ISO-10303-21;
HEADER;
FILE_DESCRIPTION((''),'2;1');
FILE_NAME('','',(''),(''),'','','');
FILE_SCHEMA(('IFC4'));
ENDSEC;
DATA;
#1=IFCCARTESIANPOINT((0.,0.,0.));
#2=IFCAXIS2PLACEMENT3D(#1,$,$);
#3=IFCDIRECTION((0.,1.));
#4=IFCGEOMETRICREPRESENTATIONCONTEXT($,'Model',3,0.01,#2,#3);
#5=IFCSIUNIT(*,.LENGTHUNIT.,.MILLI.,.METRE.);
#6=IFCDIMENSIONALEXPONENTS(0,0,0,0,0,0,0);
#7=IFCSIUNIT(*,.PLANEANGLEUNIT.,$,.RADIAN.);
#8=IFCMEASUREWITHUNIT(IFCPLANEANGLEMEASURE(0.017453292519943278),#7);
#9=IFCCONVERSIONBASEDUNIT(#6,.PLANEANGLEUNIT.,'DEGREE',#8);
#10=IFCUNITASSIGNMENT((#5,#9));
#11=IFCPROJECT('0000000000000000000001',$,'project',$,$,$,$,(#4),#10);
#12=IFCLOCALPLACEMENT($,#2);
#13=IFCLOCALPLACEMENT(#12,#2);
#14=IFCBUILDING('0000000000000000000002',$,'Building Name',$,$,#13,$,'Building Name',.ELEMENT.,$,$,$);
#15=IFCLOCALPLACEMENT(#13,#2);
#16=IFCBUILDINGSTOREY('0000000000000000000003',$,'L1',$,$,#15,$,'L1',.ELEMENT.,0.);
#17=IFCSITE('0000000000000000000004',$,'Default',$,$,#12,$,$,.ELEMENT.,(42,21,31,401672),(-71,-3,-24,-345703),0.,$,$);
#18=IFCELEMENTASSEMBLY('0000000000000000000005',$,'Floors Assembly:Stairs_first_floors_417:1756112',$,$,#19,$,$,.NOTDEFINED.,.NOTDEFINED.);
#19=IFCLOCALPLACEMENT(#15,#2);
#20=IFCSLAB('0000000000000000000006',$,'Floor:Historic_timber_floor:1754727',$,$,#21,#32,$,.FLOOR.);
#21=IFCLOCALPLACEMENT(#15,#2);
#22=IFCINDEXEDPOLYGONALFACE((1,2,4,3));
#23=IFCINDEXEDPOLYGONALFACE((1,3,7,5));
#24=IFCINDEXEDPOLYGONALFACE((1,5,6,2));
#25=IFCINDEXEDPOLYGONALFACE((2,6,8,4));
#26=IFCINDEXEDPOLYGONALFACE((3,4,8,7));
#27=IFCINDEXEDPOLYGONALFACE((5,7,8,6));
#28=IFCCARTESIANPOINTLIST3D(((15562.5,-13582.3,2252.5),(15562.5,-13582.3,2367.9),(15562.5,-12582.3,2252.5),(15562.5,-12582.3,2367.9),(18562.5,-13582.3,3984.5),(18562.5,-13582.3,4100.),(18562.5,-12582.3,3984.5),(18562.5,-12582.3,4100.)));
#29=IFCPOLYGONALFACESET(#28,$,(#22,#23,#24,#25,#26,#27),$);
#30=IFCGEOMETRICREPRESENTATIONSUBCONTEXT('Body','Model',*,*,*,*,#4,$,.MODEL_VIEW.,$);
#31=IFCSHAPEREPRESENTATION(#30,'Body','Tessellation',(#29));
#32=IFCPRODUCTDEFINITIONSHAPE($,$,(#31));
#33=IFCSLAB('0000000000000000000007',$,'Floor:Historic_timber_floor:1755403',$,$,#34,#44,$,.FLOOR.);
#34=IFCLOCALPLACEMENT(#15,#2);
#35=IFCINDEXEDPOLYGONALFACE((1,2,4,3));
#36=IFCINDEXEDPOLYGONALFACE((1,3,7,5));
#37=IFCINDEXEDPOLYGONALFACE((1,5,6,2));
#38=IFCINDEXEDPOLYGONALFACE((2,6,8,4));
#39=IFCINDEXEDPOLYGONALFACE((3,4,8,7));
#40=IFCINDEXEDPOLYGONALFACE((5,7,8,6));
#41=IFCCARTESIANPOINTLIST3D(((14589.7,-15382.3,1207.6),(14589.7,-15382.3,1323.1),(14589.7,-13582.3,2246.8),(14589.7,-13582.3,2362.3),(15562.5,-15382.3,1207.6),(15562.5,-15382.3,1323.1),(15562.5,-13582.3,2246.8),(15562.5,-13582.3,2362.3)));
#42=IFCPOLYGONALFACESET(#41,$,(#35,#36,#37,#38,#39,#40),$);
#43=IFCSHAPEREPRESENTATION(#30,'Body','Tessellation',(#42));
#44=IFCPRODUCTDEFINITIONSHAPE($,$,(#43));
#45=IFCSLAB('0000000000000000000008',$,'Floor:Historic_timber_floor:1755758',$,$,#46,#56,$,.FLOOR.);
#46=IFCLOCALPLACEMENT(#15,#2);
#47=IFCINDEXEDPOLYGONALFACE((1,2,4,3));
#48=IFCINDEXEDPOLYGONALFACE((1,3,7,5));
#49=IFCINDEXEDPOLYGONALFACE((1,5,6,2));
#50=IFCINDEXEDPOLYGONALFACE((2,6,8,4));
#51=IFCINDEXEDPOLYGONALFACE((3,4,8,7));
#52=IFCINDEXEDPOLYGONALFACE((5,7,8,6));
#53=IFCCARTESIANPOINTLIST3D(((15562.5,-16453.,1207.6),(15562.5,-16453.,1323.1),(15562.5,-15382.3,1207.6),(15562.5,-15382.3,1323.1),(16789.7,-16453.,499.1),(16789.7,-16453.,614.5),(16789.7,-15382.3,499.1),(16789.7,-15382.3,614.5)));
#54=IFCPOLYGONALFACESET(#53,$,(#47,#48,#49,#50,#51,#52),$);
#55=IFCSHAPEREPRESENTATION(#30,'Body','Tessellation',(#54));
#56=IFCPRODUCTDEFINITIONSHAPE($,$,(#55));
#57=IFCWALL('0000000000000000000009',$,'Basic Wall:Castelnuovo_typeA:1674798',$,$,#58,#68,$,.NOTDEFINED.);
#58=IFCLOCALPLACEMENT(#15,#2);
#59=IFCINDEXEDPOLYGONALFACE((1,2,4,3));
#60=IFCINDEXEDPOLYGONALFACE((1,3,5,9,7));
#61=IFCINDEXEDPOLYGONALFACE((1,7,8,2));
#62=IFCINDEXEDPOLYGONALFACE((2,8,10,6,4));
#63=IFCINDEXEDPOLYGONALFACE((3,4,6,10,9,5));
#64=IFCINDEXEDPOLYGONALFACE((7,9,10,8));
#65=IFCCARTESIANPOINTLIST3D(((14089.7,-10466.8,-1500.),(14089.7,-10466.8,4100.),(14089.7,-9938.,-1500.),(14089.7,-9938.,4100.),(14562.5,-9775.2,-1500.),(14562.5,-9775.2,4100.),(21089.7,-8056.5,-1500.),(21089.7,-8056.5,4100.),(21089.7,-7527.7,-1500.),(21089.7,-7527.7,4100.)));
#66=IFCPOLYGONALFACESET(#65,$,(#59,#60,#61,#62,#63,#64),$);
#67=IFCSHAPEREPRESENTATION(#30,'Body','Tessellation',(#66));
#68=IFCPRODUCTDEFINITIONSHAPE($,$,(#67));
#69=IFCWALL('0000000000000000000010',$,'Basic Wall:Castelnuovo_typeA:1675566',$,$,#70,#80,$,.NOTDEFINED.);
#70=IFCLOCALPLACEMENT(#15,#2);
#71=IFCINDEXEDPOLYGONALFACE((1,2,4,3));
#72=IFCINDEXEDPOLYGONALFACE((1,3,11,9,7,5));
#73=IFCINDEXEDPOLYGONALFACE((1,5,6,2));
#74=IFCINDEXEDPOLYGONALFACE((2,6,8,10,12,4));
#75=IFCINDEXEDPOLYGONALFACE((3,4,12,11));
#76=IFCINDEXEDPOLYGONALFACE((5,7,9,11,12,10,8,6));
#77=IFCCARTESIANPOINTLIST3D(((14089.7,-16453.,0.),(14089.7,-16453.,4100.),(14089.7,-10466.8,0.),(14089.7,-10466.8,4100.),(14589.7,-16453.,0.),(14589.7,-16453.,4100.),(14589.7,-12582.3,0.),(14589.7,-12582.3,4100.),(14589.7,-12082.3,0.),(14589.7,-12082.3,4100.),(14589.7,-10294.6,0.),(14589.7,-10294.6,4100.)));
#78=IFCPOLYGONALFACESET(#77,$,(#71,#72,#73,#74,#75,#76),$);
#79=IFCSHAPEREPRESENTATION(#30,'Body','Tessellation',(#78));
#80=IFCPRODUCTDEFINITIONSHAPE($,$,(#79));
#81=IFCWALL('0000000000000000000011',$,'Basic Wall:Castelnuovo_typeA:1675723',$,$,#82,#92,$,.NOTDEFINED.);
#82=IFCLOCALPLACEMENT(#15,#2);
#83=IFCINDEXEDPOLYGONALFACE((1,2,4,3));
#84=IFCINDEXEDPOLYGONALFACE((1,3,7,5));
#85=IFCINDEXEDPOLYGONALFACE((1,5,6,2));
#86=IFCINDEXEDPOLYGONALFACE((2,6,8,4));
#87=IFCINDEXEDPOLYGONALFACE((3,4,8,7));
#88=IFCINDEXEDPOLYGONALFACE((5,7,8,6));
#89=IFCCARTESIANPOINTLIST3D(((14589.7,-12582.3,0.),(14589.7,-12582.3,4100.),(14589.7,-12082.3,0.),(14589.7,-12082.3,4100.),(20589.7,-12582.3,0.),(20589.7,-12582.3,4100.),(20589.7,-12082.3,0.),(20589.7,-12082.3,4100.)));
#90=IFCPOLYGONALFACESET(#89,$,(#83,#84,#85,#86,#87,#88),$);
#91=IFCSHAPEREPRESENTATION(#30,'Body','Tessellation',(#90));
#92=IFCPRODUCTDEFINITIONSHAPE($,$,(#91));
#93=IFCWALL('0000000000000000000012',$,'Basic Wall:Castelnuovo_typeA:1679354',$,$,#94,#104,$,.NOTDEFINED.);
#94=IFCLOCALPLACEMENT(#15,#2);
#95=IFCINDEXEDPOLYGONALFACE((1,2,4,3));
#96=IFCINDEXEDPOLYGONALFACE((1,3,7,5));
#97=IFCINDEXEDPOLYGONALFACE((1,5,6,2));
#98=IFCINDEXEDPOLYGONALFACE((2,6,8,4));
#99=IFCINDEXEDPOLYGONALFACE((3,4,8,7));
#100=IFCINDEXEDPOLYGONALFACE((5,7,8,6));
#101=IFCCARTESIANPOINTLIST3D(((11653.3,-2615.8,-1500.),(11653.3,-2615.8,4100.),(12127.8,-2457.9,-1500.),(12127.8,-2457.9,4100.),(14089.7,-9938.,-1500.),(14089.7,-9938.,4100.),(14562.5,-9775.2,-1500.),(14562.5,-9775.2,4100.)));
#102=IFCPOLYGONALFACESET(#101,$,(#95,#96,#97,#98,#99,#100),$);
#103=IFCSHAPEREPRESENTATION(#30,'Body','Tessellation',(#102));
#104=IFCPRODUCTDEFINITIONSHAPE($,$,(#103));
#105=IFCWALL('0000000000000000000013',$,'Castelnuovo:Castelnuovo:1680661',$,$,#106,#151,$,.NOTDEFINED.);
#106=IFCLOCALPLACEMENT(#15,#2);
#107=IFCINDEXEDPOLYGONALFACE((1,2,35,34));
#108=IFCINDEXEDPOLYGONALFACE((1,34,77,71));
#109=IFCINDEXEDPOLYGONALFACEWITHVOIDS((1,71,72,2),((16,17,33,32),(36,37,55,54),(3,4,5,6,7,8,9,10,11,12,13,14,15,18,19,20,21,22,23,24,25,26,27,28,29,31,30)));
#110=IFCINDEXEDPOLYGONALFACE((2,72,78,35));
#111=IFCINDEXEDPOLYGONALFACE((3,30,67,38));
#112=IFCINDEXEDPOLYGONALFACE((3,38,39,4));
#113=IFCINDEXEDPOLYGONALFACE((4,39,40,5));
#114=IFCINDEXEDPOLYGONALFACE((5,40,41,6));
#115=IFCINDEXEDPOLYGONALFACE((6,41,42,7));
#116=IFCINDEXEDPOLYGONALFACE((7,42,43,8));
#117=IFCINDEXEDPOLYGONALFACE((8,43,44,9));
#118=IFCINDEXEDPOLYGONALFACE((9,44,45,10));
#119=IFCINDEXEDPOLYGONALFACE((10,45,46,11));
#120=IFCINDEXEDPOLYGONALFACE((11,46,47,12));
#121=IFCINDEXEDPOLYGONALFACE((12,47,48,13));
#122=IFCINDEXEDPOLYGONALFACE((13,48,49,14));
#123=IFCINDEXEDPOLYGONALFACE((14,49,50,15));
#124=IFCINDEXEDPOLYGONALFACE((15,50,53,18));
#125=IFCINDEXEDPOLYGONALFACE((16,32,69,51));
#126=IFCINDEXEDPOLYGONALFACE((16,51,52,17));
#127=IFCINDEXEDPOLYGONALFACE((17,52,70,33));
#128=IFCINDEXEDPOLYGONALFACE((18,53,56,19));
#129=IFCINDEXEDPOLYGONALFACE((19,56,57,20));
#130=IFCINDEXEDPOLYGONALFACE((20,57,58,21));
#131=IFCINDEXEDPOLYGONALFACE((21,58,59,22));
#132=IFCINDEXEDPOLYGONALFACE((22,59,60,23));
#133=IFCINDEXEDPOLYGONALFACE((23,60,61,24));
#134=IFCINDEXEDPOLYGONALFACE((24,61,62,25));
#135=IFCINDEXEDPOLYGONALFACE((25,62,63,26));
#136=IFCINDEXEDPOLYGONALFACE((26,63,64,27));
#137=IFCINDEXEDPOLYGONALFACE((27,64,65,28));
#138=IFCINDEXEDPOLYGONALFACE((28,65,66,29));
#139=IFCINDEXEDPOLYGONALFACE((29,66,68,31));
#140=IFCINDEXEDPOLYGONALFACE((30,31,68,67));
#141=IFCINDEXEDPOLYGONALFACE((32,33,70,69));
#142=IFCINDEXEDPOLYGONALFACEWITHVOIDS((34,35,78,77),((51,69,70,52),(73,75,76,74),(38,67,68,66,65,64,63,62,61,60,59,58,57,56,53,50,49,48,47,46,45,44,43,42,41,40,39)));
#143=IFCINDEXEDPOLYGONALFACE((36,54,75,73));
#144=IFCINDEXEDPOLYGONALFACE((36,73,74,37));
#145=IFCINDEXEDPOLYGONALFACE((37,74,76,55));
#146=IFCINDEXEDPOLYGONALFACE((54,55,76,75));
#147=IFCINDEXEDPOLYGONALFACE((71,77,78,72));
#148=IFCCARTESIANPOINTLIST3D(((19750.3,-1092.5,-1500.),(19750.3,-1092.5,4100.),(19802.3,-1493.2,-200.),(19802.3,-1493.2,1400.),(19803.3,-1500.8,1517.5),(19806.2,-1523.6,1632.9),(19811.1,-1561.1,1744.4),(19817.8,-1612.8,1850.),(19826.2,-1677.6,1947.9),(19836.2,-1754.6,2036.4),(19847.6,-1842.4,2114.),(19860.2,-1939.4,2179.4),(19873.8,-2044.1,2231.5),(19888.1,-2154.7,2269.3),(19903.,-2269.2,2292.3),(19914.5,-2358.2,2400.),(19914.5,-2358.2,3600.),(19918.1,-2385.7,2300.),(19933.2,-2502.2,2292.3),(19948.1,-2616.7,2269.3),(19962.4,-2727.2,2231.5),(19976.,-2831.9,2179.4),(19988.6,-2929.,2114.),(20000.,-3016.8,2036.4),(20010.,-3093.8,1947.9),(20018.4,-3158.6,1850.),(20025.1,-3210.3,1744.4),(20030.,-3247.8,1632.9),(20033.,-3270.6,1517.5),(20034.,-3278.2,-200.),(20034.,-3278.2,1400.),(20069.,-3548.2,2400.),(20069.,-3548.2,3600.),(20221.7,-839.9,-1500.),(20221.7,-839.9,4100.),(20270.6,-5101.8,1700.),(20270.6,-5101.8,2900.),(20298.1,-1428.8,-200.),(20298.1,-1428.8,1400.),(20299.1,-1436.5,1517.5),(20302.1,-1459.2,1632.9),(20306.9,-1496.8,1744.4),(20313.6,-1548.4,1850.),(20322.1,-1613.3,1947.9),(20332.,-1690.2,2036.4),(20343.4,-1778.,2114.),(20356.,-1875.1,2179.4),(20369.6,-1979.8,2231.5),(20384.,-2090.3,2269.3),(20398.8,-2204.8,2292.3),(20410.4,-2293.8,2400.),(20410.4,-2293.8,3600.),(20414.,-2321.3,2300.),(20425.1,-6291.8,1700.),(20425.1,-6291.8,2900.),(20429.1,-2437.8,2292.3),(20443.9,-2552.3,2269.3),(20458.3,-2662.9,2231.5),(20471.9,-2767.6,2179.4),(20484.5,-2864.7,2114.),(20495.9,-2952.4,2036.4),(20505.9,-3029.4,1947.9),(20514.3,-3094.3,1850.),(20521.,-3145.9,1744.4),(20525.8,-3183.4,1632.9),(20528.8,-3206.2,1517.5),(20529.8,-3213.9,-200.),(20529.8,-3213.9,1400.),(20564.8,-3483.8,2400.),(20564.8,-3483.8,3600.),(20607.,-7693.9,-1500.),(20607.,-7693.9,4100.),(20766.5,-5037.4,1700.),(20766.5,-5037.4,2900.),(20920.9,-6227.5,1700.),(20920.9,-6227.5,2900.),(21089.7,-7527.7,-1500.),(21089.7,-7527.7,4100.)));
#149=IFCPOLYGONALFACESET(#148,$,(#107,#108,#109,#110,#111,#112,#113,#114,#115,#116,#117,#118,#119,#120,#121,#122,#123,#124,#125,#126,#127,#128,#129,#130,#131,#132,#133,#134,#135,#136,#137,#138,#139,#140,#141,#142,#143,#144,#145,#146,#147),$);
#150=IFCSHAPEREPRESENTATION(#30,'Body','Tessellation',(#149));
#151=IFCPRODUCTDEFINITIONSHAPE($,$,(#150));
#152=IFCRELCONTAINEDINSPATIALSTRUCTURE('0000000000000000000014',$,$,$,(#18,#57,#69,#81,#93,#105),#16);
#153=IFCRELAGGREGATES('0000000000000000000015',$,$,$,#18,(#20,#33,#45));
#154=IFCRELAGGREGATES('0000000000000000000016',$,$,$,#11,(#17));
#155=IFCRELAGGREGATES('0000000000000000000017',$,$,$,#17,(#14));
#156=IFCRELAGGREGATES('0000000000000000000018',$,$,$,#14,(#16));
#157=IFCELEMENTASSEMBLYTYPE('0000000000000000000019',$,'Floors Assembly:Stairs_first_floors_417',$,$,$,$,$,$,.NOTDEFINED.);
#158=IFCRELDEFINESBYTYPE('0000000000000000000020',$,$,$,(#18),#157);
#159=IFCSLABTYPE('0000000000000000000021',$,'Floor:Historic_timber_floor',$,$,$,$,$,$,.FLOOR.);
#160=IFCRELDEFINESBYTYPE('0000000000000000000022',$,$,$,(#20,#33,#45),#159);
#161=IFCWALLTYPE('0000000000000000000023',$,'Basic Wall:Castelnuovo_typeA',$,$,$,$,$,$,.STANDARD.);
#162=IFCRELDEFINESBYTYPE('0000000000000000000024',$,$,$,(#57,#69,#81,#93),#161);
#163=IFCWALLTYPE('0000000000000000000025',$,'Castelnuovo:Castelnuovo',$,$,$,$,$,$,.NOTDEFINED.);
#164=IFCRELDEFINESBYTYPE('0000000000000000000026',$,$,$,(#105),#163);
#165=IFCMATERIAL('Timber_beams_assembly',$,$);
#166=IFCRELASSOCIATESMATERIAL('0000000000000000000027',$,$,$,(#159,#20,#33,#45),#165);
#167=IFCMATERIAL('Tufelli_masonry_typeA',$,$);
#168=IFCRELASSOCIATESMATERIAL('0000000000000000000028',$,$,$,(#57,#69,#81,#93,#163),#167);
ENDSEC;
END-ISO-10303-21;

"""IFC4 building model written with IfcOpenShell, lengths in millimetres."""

from ifc_helpers import new_model, entity, si_unit, converted_unit, direction, frame, frame_2d, origin, place, context, subcontext, project, spatial, line, arc, indexed_curve, rectangle, outline, extrude, material, type_object, element, aggregate, save


model = new_model("IFC4")

# Units and contexts
model_context = context("Model", 3, precision=0.01, world=origin(), true_north=direction((0.0, 1.0)))
body_context = subcontext(model_context, "Body", "Model", "MODEL_VIEW")
ifc_project = project(units=[si_unit("LENGTHUNIT", "METRE", prefix="MILLI"), converted_unit("PLANEANGLEUNIT", "DEGREE", entity("IfcPlaneAngleMeasure", 0.017453292519943278), si_unit("PLANEANGLEUNIT", "RADIAN"), dimensions=[0, 0, 0, 0, 0, 0, 0])], contexts=[model_context])

# Site, building, storey
site_placement = place(None, origin())
site = spatial("IfcSite", under=ifc_project, at=site_placement, Name="Default", CompositionType="ELEMENT", RefLatitude=(42, 21, 31, 401672), RefLongitude=(-71, -3, -24, -345703), RefElevation=0.0)
building_placement = place(site_placement, origin())
building = spatial("IfcBuilding", under=site, at=building_placement, Name="Building Name", LongName="Building Name", CompositionType="ELEMENT")
storey_placement = place(building_placement, origin())
storey = spatial("IfcBuildingStorey", under=building, at=storey_placement, Name="L1", LongName="L1", CompositionType="ELEMENT", Elevation=0.0)

# Element assembly, slabs
element_assembly_type = type_object("IfcElementAssemblyType", Name="Floors Assembly:Stairs_first_floors_417", PredefinedType="NOTDEFINED")
assembly_placement = place(storey_placement, origin())
assembly = element("IfcElementAssembly", 1, at=assembly_placement, inside=storey, type_object=element_assembly_type, Name="Floors Assembly:Stairs_first_floors_417:1756112", AssemblyPlace="NOTDEFINED", PredefinedType="NOTDEFINED")
ifc_material_1 = material(Name="Timber_beams_assembly")
slab_type = type_object("IfcSlabType", Name="Floor:Historic_timber_floor", PredefinedType="FLOOR", material=ifc_material_1)
slab_1_placement = place(assembly_placement, frame((15562.5, -13582.3, 2252.5)))
slab_1 = element("IfcSlab", 2, at=slab_1_placement, type_object=slab_type, material=ifc_material_1, Name="Floor:Historic_timber_floor:1754727", PredefinedType="FLOOR", context=body_context, shape_type="SweptSolid", body=[
    extrude(rectangle(XDim=1000.0, YDim=3464.1, at=frame_2d((-1732.1, -500.0), x_axis=(0.0, -1.0))), frame((3000.0, 1000.0, 1847.5), z_axis=(-0.5, 0.0, 0.866025), x_axis=(0.866025, 0.0, 0.5)), (-0.5, 0.0, -0.866025), 115.5),
])
slab_2_placement = place(assembly_placement, frame((14589.7, -15382.3, 1207.6)))
slab_2 = element("IfcSlab", 3, at=slab_2_placement, type_object=slab_type, material=ifc_material_1, Name="Floor:Historic_timber_floor:1755403", PredefinedType="FLOOR", context=body_context, shape_type="SweptSolid", body=[
    extrude(rectangle(XDim=972.8, YDim=2078.5, at=frame_2d((486.4, -1039.2), x_axis=(1.0, 0.0))), frame((0.0, 1800.0, 1154.7), z_axis=(0.0, -0.5, 0.866025), x_axis=(1.0, 0.0, 0.0)), (0.0, -0.5, -0.866025), 115.5),
])
slab_3_placement = place(assembly_placement, frame((15562.5, -16453.0, 499.1)))
slab_3 = element("IfcSlab", 4, at=slab_3_placement, type_object=slab_type, material=ifc_material_1, Name="Floor:Historic_timber_floor:1755758", PredefinedType="FLOOR", context=body_context, shape_type="SweptSolid", body=[
    extrude(rectangle(XDim=1070.7, YDim=1417.1, at=frame_2d((708.5, 535.3), x_axis=(0.0, -1.0))), frame((0.0, 0.0, 824.0), z_axis=(0.5, 0.0, 0.866025), x_axis=(0.866025, 0.0, -0.5)), (0.5, 0.0, -0.866025), 115.5),
])
aggregate(assembly, [slab_1, slab_2, slab_3])

# Walls
ifc_material_2 = material(Name="Tufelli_masonry_typeA")
wall_type_1 = type_object("IfcWallType", Name="Basic Wall:Castelnuovo_typeA", PredefinedType="STANDARD")
wall_1_placement = place(storey_placement, frame((14008.3, -10230.4, -1500.0), z_axis=(0.0, 0.0, 1.0), x_axis=(0.945519, 0.325568, 0.0)))
element("IfcWall", 5, at=wall_1_placement, inside=storey, type_object=wall_type_1, material=ifc_material_2, Name="Basic Wall:Castelnuovo_typeA:1674798", PredefinedType="NOTDEFINED", context=body_context, shape_type="SweptSolid", body=[
    extrude(outline(indexed_curve([(7403.3, -250.0), (7575.5, 250.0), (672.2, 250.0), (172.2, 250.0), (0.0, -250.0), (7403.3, -250.0)], self_intersect=False)), origin(), (0.0, 0.0, 1.0), 5600.0),
])
wall_2_placement = place(storey_placement, frame((14339.7, -16453.0, 0.0), z_axis=(0.0, 0.0, 1.0), x_axis=(0.0, 1.0, 0.0)))
element("IfcWall", 6, at=wall_2_placement, inside=storey, type_object=wall_type_1, material=ifc_material_2, Name="Basic Wall:Castelnuovo_typeA:1675566", PredefinedType="NOTDEFINED", context=body_context, shape_type="SweptSolid", body=[
    extrude(outline(indexed_curve([(6158.4, -250.0), (5986.3, 250.0), (0.0, 250.0), (0.0, -250.0), (3870.7, -250.0), (4370.7, -250.0), (6158.4, -250.0)], self_intersect=False)), origin(), (0.0, 0.0, 1.0), 4100.0),
])
wall_3_placement = place(storey_placement, frame((14589.7, -12332.3, 0.0)))
element("IfcWall", 7, at=wall_3_placement, inside=storey, type_object=wall_type_1, material=ifc_material_2, Name="Basic Wall:Castelnuovo_typeA:1675723", PredefinedType="NOTDEFINED", context=body_context, shape_type="SweptSolid", body=[
    extrude(outline(indexed_curve([(6000.0, 250.0), (0.0, 250.0), (0.0, -250.0), (6000.0, -250.0), (6000.0, 250.0)], self_intersect=False)), origin(), (0.0, 0.0, 1.0), 4100.0),
])
wall_4_placement = place(storey_placement, frame((11890.5, -2536.8, -1500.0), z_axis=(0.0, 0.0, 1.0), x_axis=(0.315716, -0.948854, 0.0)))
element("IfcWall", 8, at=wall_4_placement, inside=storey, type_object=wall_type_1, material=ifc_material_2, Name="Basic Wall:Castelnuovo_typeA:1679354", PredefinedType="NOTDEFINED", context=body_context, shape_type="SweptSolid", body=[
    extrude(outline(indexed_curve([(7716.9, -250.0), (7711.7, 250.0), (0.0, 250.0), (0.0, -250.0), (7716.9, -250.0)], self_intersect=False)), origin(), (0.0, 0.0, 1.0), 5600.0),
])

# Wall, openings
wall_type_2 = type_object("IfcWallType", Name="Castelnuovo:Castelnuovo", PredefinedType="NOTDEFINED", material=ifc_material_2)
wall_5_placement = place(storey_placement, frame((19750.3, -7693.9, -1500.0), z_axis=(0.0, 0.0, 1.0), x_axis=(0.0, 1.0, 0.0)))
wall_5 = element("IfcWall", 9, at=wall_5_placement, inside=storey, type_object=wall_type_2, Name="Castelnuovo:Castelnuovo:1680661", PredefinedType="NOTDEFINED", context=body_context, shape_type="SweptSolid", body=[
    extrude(outline(indexed_curve([(-929.1, -3281.7), (-418.7, -3281.7), (937.9, 3324.4), (409.9, 3239.0), (-929.1, -3281.7)], self_intersect=False)), frame((3405.4, -666.9, 0.0), z_axis=(0.0, 0.0, 1.0), x_axis=(0.325568, -0.945519, 0.0)), (0.0, 0.0, 1.0), 5600.0),
])
opening_1_placement = place(wall_5_placement, origin())
element("IfcOpeningElement", 10, at=opening_1_placement, cuts=wall_5, PredefinedType="OPENING", context=body_context, shape_type="SweptSolid", body=[
    extrude(outline(indexed_curve([(-600.0, -600.0), (600.0, -600.0), (600.0, 600.0), (-600.0, 600.0), (-600.0, -600.0)], self_intersect=False)), frame((1994.5, -577.7, 3800.0), z_axis=(0.128709, -0.991682, 0.0), x_axis=(0.0, 0.0, 1.0)), (0.0, 0.0, 1.0), 590.0),
])
opening_2_placement = place(wall_5_placement, origin())
element("IfcOpeningElement", 11, at=opening_2_placement, cuts=wall_5, PredefinedType="OPENING", context=body_context, shape_type="SweptSolid", body=[
    extrude(outline(indexed_curve([(-600.0, -600.0), (600.0, -600.0), (600.0, 600.0), (-600.0, 600.0), (-600.0, -600.0)], self_intersect=False)), frame((4738.1, -221.7, 4500.0), z_axis=(0.128709, -0.991682, 0.0), x_axis=(0.0, 0.0, 1.0)), (0.0, 0.0, 1.0), 590.0),
])
opening_3_placement = place(wall_5_placement, origin())
element("IfcOpeningElement", 12, at=opening_3_placement, cuts=wall_5, PredefinedType="OPENING", context=body_context, shape_type="SweptSolid", body=[
    extrude(outline(indexed_curve([(-800.0, -900.0), (800.0, -900.0), (800.0, 900.0), (-800.0, 900.0), (-1700.0, 0.0)], segments=[line(1, 2, 3, 4), arc(4, 5, 1)], self_intersect=False)), frame((5375.1, -683.5, 2100.0), z_axis=(-0.128709, 0.991682, 0.0), x_axis=(0.0, 0.0, -1.0)), (0.0, 0.0, 1.0), 1590.0),
])

save(model, "model.ifc")
